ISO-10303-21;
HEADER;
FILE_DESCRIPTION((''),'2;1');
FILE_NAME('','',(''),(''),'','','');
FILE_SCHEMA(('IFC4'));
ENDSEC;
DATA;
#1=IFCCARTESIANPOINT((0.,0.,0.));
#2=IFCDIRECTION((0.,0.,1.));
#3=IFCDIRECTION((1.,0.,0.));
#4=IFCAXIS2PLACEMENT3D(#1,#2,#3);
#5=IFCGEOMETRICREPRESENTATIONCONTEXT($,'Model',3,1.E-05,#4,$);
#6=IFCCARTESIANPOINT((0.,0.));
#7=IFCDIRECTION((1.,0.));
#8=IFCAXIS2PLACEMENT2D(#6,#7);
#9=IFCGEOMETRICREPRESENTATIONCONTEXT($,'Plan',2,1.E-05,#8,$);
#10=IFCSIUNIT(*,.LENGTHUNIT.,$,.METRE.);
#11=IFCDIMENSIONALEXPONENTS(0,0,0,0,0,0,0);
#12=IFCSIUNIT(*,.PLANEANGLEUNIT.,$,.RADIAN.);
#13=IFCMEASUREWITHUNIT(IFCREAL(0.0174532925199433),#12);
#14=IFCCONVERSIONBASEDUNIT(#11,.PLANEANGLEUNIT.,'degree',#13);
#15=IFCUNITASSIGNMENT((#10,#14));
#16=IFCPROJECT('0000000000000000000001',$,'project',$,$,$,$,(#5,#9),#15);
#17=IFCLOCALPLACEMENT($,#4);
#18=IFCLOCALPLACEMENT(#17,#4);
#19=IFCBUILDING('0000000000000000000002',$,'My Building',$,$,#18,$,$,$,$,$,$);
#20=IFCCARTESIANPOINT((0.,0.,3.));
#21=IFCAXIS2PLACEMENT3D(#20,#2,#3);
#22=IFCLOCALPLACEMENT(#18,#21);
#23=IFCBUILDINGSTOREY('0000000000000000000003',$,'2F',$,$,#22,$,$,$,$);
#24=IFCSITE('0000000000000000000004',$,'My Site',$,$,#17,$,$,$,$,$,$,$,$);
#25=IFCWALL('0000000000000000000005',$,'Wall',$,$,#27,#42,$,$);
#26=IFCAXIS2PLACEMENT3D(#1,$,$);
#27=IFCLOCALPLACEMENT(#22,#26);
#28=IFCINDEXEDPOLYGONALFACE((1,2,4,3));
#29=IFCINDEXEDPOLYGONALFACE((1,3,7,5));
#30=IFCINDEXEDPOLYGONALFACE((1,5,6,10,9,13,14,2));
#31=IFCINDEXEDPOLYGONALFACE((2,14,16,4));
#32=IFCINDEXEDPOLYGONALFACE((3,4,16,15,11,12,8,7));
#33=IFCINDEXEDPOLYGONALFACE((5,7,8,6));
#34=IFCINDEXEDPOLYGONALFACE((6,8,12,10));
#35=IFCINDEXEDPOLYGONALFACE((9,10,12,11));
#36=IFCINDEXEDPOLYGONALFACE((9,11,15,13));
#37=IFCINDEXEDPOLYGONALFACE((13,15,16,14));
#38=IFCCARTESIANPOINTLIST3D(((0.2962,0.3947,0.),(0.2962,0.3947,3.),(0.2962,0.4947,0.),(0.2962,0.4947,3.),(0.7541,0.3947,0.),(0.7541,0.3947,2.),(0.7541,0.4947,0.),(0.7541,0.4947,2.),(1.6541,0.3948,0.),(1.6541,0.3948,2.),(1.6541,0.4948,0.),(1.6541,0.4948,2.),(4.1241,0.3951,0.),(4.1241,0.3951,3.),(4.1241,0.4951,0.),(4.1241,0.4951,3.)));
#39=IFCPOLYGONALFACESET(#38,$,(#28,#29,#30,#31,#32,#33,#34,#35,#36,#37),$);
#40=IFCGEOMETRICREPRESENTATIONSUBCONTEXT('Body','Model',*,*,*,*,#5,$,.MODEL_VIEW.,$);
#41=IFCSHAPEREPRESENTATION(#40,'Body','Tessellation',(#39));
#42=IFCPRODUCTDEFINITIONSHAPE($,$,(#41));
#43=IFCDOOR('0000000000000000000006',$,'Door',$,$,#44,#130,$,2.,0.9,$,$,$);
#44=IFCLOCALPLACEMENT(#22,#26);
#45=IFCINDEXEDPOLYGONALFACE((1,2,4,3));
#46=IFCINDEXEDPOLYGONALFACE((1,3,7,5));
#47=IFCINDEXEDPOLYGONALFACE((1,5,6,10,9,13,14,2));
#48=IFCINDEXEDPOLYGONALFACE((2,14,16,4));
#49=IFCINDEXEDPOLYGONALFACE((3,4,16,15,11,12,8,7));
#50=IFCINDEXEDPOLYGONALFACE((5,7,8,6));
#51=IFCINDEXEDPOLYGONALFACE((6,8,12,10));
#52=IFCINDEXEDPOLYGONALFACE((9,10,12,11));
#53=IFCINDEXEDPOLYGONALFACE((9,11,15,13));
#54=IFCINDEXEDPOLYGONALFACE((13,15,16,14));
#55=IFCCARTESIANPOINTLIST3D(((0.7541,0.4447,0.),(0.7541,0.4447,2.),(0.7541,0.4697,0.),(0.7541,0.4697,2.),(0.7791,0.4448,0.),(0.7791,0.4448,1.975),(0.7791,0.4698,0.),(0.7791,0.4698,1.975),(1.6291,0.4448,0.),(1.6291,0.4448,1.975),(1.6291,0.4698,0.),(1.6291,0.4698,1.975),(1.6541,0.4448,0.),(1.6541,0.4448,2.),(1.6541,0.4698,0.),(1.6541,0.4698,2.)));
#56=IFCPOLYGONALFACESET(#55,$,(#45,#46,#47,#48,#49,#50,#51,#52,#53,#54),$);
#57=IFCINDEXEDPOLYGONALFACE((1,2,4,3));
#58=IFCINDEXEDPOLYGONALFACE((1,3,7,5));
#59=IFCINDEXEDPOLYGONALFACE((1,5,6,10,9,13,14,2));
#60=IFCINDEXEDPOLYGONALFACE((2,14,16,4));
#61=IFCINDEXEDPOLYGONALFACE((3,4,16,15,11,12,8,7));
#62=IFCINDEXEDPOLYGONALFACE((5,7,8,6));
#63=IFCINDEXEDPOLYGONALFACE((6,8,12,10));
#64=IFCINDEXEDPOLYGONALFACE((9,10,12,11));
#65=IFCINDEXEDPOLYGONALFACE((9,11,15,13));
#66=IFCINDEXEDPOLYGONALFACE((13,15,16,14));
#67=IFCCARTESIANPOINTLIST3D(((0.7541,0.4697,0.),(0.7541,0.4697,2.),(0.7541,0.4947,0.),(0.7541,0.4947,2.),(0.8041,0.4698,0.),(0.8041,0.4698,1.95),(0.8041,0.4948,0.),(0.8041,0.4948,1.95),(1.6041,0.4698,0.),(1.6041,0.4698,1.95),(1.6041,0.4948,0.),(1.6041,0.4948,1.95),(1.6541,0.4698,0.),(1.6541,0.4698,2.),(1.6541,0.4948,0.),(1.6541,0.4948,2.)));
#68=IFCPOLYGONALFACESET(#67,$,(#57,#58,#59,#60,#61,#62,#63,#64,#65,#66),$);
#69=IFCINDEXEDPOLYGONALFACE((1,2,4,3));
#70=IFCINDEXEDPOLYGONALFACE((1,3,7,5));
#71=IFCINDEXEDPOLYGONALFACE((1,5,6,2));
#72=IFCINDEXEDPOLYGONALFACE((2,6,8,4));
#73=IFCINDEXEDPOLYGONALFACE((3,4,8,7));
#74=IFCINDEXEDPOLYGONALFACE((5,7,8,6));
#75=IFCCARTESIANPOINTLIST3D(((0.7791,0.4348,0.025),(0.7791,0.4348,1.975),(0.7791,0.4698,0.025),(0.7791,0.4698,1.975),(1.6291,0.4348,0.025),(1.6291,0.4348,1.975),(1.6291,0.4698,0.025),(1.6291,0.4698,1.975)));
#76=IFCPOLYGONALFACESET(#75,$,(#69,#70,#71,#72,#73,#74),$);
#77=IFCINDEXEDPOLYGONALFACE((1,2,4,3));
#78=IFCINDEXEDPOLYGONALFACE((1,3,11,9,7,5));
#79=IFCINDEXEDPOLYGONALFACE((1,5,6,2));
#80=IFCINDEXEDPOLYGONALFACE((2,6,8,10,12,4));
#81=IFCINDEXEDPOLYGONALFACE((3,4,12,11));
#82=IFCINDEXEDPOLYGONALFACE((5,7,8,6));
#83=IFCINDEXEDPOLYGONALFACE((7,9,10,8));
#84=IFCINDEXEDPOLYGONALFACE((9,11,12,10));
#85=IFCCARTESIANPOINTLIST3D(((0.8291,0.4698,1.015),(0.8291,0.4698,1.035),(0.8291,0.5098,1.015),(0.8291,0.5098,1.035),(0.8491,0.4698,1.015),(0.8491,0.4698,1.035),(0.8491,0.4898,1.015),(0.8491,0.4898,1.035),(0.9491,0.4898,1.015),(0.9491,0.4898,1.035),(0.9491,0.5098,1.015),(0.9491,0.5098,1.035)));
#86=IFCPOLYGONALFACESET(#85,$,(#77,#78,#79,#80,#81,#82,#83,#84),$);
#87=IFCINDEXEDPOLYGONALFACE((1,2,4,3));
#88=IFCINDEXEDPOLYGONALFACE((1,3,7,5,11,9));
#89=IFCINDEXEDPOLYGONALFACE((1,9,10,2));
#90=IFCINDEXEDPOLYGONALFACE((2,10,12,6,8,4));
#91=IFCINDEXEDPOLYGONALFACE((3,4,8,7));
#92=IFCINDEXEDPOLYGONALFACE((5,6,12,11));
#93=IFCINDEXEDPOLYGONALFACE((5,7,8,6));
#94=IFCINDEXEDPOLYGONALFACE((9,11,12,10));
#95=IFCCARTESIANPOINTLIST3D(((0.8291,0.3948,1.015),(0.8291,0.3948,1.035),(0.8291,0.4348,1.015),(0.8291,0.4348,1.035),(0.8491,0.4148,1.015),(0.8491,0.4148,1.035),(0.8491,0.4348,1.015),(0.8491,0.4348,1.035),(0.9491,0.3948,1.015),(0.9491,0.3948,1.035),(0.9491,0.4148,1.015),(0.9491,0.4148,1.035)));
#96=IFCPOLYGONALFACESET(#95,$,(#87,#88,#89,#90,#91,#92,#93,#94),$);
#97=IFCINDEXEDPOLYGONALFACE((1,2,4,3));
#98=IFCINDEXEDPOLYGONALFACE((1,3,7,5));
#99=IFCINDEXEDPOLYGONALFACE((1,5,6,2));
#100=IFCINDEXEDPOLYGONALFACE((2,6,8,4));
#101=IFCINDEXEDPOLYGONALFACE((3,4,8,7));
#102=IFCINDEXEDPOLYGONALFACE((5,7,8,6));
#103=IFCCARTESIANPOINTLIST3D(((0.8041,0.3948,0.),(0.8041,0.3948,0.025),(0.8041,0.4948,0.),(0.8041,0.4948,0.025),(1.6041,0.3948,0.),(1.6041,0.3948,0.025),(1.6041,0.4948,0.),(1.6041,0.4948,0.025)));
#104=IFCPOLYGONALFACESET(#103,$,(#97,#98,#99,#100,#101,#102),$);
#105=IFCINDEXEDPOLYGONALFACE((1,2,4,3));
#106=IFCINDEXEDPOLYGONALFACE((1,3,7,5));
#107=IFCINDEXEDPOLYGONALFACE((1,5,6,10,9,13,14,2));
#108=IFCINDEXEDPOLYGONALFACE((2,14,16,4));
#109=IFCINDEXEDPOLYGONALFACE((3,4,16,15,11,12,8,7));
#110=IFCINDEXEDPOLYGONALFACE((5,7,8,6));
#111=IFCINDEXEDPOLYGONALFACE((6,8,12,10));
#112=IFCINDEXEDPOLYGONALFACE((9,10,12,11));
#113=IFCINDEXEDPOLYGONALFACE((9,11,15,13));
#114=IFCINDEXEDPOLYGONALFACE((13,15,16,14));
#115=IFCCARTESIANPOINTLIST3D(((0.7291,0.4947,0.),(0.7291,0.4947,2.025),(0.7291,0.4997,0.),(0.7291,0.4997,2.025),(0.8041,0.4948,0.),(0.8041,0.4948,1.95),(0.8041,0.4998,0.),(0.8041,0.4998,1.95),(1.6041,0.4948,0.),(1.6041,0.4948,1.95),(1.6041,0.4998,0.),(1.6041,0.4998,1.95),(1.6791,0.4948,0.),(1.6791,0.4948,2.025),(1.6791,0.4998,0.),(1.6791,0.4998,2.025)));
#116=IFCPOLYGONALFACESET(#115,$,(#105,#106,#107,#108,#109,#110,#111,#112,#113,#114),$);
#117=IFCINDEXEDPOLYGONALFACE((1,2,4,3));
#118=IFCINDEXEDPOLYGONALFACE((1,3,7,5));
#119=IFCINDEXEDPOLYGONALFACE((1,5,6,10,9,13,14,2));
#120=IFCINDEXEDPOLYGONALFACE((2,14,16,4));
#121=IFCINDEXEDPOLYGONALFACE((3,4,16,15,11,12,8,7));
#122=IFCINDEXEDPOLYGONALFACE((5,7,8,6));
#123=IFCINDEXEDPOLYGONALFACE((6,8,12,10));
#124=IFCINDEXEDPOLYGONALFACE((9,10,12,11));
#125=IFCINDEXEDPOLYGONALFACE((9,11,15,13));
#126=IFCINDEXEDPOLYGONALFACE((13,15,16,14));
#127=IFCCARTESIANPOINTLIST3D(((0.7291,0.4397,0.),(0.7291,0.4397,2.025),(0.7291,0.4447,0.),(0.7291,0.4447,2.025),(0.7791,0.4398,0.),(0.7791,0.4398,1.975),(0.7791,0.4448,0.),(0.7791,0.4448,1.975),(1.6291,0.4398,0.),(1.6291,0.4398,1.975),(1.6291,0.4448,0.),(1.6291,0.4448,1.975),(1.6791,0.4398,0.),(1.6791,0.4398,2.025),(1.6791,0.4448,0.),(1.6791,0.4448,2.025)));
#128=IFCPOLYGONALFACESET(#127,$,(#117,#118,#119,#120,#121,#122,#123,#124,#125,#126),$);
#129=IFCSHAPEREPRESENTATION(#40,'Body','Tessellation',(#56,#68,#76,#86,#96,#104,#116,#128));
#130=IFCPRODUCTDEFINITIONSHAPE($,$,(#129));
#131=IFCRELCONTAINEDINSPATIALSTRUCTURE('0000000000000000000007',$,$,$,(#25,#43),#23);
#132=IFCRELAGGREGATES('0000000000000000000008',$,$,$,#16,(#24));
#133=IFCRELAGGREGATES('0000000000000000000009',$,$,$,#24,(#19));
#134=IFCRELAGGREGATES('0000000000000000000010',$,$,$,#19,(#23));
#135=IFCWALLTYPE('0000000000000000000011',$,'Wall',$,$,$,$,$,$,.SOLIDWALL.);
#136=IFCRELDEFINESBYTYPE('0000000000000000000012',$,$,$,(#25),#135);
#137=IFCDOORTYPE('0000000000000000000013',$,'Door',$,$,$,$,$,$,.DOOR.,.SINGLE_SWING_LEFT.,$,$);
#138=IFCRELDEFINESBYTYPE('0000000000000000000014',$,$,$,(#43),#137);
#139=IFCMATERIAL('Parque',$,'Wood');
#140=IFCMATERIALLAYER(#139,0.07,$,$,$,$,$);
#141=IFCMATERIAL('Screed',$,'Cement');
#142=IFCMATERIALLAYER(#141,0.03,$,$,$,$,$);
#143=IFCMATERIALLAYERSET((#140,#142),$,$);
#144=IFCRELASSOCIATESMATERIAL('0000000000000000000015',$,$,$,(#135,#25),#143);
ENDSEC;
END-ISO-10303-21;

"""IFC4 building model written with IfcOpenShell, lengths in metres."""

from ifc_helpers import new_model, entity, si_unit, converted_unit, frame, origin_with_axes, origin_2d_with_axis, place, context, subcontext, project, spatial, line, indexed_curve, outline, extrude, shape, source, transform, mapped, material, layer, layer_set, layer_usage, type_object, type_shapes, element, fill, save


model = new_model("IFC4")

# Units and contexts
model_context = context("Model", 3, precision=1e-05, world=origin_with_axes())
plan_context = context("Plan", 2, precision=1e-05, world=origin_2d_with_axis())
body_context_1 = subcontext(model_context, "Body", "Model", "MODEL_VIEW")
body_context_2 = subcontext(plan_context, "Body", "Plan", "PLAN_VIEW")
ifc_project = project(units=[si_unit("LENGTHUNIT", "METRE"), converted_unit("PLANEANGLEUNIT", "degree", entity("IfcReal", 0.0174532925199433), si_unit("PLANEANGLEUNIT", "RADIAN"), dimensions=[0, 0, 0, 0, 0, 0, 0])], contexts=[model_context, plan_context])

# Site, building, storey
site_placement = place(None, origin_with_axes())
site = spatial("IfcSite", under=ifc_project, at=site_placement, Name="My Site")
building_placement = place(site_placement, origin_with_axes())
building = spatial("IfcBuilding", under=site, at=building_placement, Name="My Building")
storey_placement = place(building_placement, frame((0.0, 0.0, 3.0), z_axis=(0.0, 0.0, 1.0), x_axis=(1.0, 0.0, 0.0)))
storey = spatial("IfcBuildingStorey", under=building, at=storey_placement, Name="2F")

# Shared definitions
ifc_material_1 = material(Name="Parque", Category="Wood")
ifc_layer_1 = layer(ifc_material_1, 0.07)
ifc_material_2 = material(Name="Screed", Category="Cement")
ifc_layer_2 = layer(ifc_material_2, 0.03)
ifc_layer_set_1 = layer_set([ifc_layer_1, ifc_layer_2])
wall_type = type_object("IfcWallType", Name="Wall", PredefinedType="SOLIDWALL", material=ifc_layer_set_1)

# Shared definitions
shared_shape_1 = source(origin_with_axes(), body_context_1, "Body", "SweptSolid", [
    extrude(outline(indexed_curve([(0.0, 0.0), (0.9, 0.0), (0.9, 2.0), (0.0, 2.0)], segments=[line(1, 2, 3, 4, 1)])), frame((0.0, -0.6, 0.0), z_axis=(0.0, -1.0, 0.0), x_axis=(1.0, 0.0, 0.0)), (0.0, 0.0, -1.0), 1.2),
])
door_type = type_object("IfcDoorType", Name="Door", OperationType="SINGLE_SWING_LEFT", PredefinedType="DOOR")
shared_shape_2 = source(origin_with_axes(), body_context_1, "Body", "SweptSolid", [
    extrude(outline(indexed_curve([(0.0, 0.0), (0.0, 2.0), (0.9, 2.0), (0.9, 0.0), (0.875, 0.0), (0.875, 1.975), (0.025, 1.975), (0.025, 0.0)], segments=[line(1, 2, 3, 4, 5, 6, 7, 8, 1)])), frame((0.0, 0.025, 0.0), z_axis=(0.0, -1.0, 0.0), x_axis=(1.0, 0.0, 0.0)), (0.0, 0.0, -1.0), 0.025),
    extrude(outline(indexed_curve([(0.0, 0.0), (0.0, 2.0), (0.9, 2.0), (0.9, 0.0), (0.85, 0.0), (0.85, 1.95), (0.05, 1.95), (0.05, 0.0)], segments=[line(1, 2, 3, 4, 5, 6, 7, 8, 1)])), frame((0.0, 0.0, 0.0), z_axis=(0.0, -1.0, 0.0), x_axis=(1.0, 0.0, 0.0)), (0.0, 0.0, -1.0), 0.025),
    extrude(outline(indexed_curve([(0.0, 0.0), (0.85, 0.0), (0.85, 0.035), (0.0, 0.035)], segments=[line(1, 2, 3, 4, 1)])), frame((0.025, 0.025, 0.025), z_axis=(0.0, 0.0, 1.0), x_axis=(1.0, 0.0, 0.0)), (0.0, 0.0, 1.0), 1.95),
    extrude(outline(indexed_curve([(0.0, 0.0), (0.0, -0.04), (-0.12, -0.04), (-0.12, -0.02), (-0.02, -0.02), (-0.02, 0.0)], segments=[line(1, 2, 3, 4, 5, 6, 1)])), frame((0.825, 0.025, 1.015), z_axis=(0.0, 0.0, 1.0), x_axis=(1.0, 0.0, 0.0)), (0.0, 0.0, 1.0), 0.02),
    extrude(outline(indexed_curve([(0.0, 0.0), (0.0, 0.04), (-0.12, 0.04), (-0.12, 0.02), (-0.02, 0.02), (-0.02, 0.0)], segments=[line(1, 2, 3, 4, 5, 6, 1)])), frame((0.825, 0.06, 1.015), z_axis=(0.0, 0.0, 1.0), x_axis=(1.0, 0.0, 0.0)), (0.0, 0.0, 1.0), 0.02),
    extrude(outline(indexed_curve([(0.0, 0.0), (0.8, 0.0), (0.8, 0.1), (0.0, 0.1)], segments=[line(1, 2, 3, 4, 1)])), frame((0.05, 0.0, 0.0), z_axis=(0.0, 0.0, 1.0), x_axis=(1.0, 0.0, 0.0)), (0.0, 0.0, 1.0), 0.025),
    extrude(outline(indexed_curve([(0.0, 0.0), (0.0, 2.025), (0.95, 2.025), (0.95, 0.0), (0.875, 0.0), (0.875, 1.95), (0.075, 1.95), (0.075, 0.0)], segments=[line(1, 2, 3, 4, 5, 6, 7, 8, 1)])), frame((-0.025, -0.005, 0.0), z_axis=(0.0, -1.0, 0.0), x_axis=(1.0, 0.0, 0.0)), (0.0, 0.0, -1.0), 0.005),
    extrude(outline(indexed_curve([(0.0, 0.0), (0.0, 2.025), (0.95, 2.025), (0.95, 0.0), (0.9, 0.0), (0.9, 1.975), (0.05, 1.975), (0.05, 0.0)], segments=[line(1, 2, 3, 4, 5, 6, 7, 8, 1)])), frame((-0.025, 0.05, 0.0), z_axis=(0.0, -1.0, 0.0), x_axis=(1.0, 0.0, 0.0)), (0.0, 0.0, -1.0), 0.005),
])
shared_shape_3 = source(origin_with_axes(), body_context_2, "Body", "Curve2D", [
    entity("IfcIndexedPolyCurve", entity("IfcCartesianPointList2D", [[0.0, 0.0], [0.0, 0.05], [0.025, 0.05], [0.025, 0.025], [0.05, 0.025], [0.05, 0.0]]), [entity("IfcLineIndex", [1, 2, 3, 4, 5, 6, 1])]),
    entity("IfcIndexedPolyCurve", entity("IfcCartesianPointList2D", [[0.9, 0.0], [0.9, 0.05], [0.875, 0.05], [0.875, 0.025], [0.85, 0.025], [0.85, 0.0]]), [entity("IfcLineIndex", [1, 2, 3, 4, 5, 6, 1])]),
    entity("IfcTrimmedCurve", entity("IfcEllipse", entity("IfcAxis2Placement2D", entity("IfcCartesianPoint", [0.06, 0.05]), entity("IfcDirection", [1.0, 0.0])), 0.815, 0.85), [entity("IfcCartesianPoint", [0.875, 0.05])], [entity("IfcCartesianPoint", [0.06, 0.9])], True, "CARTESIAN"),
    entity("IfcIndexedPolyCurve", entity("IfcCartesianPointList2D", [[0.025, 0.05], [0.06, 0.05], [0.06, 0.9], [0.025, 0.9]]), [entity("IfcLineIndex", [1, 2, 3, 4, 1])]),
])
type_shapes(door_type, [shared_shape_2, shared_shape_3])

# Wall, opening, door
ifc_layer_usage_1 = layer_usage(ifc_layer_set_1, "AXIS2", "POSITIVE", 0.0)
wall_1_placement = place(storey_placement, frame((4.1241, 0.4951, 0.0), z_axis=(0.0, 0.0, 1.0), x_axis=(-1.0, -0.000094, 0.0)))
wall_1 = element("IfcWall", 1, at=wall_1_placement, inside=storey, type_object=wall_type, material=ifc_layer_usage_1, Name="Wall", context=body_context_1, shape_type="SweptSolid", body=[
    extrude(outline(indexed_curve([(0.0, 0.0), (0.0, 0.1), (3.8279, 0.1), (3.8279, 0.0)], segments=[line(1, 2, 3, 4, 1)])), origin_with_axes(), (0.0, 0.0, 1.0), 3.0),
])
opening_1_placement = place(wall_1_placement, frame((2.47, 0.0, 0.0), z_axis=(0.0, 0.0, 1.0), x_axis=(1.0, 0.0, 0.0)))
opening_1 = element("IfcOpeningElement", 2, at=opening_1_placement, cuts=wall_1, PredefinedType="OPENING", context=body_context_1, shape_type="MappedRepresentation", body=[
    mapped(shared_shape_1, transform((0.0, 0.0, 0.0), x_axis=(1.0, 0.0, 0.0), y_axis=(0.0, 1.0, 0.0), z_axis=(0.0, 0.0, 1.0), scale=1.0)),
])
door_1_placement = place(opening_1_placement, frame((0.0, 0.0, 0.0), z_axis=(0.0, 0.0, 1.0), x_axis=(1.0, 0.0, 0.0)))
door_1 = element("IfcDoor", 3, at=door_1_placement, inside=storey, type_object=door_type, Name="Door", OverallHeight=2.0, OverallWidth=0.9, shapes=[
    shape(body_context_1, "Body", "MappedRepresentation", [mapped(shared_shape_2, transform((0.0, 0.0, 0.0), x_axis=(1.0, 0.0, 0.0), y_axis=(0.0, 1.0, 0.0), z_axis=(0.0, 0.0, 1.0), scale=1.0))]),
    shape(body_context_2, "Body", "MappedRepresentation", [mapped(shared_shape_3, transform((0.0, 0.0, 0.0), x_axis=(1.0, 0.0, 0.0), y_axis=(0.0, 1.0, 0.0), z_axis=(0.0, 0.0, 1.0), scale=1.0))]),
])
fill(opening_1, door_1)

save(model, "model.ifc")
